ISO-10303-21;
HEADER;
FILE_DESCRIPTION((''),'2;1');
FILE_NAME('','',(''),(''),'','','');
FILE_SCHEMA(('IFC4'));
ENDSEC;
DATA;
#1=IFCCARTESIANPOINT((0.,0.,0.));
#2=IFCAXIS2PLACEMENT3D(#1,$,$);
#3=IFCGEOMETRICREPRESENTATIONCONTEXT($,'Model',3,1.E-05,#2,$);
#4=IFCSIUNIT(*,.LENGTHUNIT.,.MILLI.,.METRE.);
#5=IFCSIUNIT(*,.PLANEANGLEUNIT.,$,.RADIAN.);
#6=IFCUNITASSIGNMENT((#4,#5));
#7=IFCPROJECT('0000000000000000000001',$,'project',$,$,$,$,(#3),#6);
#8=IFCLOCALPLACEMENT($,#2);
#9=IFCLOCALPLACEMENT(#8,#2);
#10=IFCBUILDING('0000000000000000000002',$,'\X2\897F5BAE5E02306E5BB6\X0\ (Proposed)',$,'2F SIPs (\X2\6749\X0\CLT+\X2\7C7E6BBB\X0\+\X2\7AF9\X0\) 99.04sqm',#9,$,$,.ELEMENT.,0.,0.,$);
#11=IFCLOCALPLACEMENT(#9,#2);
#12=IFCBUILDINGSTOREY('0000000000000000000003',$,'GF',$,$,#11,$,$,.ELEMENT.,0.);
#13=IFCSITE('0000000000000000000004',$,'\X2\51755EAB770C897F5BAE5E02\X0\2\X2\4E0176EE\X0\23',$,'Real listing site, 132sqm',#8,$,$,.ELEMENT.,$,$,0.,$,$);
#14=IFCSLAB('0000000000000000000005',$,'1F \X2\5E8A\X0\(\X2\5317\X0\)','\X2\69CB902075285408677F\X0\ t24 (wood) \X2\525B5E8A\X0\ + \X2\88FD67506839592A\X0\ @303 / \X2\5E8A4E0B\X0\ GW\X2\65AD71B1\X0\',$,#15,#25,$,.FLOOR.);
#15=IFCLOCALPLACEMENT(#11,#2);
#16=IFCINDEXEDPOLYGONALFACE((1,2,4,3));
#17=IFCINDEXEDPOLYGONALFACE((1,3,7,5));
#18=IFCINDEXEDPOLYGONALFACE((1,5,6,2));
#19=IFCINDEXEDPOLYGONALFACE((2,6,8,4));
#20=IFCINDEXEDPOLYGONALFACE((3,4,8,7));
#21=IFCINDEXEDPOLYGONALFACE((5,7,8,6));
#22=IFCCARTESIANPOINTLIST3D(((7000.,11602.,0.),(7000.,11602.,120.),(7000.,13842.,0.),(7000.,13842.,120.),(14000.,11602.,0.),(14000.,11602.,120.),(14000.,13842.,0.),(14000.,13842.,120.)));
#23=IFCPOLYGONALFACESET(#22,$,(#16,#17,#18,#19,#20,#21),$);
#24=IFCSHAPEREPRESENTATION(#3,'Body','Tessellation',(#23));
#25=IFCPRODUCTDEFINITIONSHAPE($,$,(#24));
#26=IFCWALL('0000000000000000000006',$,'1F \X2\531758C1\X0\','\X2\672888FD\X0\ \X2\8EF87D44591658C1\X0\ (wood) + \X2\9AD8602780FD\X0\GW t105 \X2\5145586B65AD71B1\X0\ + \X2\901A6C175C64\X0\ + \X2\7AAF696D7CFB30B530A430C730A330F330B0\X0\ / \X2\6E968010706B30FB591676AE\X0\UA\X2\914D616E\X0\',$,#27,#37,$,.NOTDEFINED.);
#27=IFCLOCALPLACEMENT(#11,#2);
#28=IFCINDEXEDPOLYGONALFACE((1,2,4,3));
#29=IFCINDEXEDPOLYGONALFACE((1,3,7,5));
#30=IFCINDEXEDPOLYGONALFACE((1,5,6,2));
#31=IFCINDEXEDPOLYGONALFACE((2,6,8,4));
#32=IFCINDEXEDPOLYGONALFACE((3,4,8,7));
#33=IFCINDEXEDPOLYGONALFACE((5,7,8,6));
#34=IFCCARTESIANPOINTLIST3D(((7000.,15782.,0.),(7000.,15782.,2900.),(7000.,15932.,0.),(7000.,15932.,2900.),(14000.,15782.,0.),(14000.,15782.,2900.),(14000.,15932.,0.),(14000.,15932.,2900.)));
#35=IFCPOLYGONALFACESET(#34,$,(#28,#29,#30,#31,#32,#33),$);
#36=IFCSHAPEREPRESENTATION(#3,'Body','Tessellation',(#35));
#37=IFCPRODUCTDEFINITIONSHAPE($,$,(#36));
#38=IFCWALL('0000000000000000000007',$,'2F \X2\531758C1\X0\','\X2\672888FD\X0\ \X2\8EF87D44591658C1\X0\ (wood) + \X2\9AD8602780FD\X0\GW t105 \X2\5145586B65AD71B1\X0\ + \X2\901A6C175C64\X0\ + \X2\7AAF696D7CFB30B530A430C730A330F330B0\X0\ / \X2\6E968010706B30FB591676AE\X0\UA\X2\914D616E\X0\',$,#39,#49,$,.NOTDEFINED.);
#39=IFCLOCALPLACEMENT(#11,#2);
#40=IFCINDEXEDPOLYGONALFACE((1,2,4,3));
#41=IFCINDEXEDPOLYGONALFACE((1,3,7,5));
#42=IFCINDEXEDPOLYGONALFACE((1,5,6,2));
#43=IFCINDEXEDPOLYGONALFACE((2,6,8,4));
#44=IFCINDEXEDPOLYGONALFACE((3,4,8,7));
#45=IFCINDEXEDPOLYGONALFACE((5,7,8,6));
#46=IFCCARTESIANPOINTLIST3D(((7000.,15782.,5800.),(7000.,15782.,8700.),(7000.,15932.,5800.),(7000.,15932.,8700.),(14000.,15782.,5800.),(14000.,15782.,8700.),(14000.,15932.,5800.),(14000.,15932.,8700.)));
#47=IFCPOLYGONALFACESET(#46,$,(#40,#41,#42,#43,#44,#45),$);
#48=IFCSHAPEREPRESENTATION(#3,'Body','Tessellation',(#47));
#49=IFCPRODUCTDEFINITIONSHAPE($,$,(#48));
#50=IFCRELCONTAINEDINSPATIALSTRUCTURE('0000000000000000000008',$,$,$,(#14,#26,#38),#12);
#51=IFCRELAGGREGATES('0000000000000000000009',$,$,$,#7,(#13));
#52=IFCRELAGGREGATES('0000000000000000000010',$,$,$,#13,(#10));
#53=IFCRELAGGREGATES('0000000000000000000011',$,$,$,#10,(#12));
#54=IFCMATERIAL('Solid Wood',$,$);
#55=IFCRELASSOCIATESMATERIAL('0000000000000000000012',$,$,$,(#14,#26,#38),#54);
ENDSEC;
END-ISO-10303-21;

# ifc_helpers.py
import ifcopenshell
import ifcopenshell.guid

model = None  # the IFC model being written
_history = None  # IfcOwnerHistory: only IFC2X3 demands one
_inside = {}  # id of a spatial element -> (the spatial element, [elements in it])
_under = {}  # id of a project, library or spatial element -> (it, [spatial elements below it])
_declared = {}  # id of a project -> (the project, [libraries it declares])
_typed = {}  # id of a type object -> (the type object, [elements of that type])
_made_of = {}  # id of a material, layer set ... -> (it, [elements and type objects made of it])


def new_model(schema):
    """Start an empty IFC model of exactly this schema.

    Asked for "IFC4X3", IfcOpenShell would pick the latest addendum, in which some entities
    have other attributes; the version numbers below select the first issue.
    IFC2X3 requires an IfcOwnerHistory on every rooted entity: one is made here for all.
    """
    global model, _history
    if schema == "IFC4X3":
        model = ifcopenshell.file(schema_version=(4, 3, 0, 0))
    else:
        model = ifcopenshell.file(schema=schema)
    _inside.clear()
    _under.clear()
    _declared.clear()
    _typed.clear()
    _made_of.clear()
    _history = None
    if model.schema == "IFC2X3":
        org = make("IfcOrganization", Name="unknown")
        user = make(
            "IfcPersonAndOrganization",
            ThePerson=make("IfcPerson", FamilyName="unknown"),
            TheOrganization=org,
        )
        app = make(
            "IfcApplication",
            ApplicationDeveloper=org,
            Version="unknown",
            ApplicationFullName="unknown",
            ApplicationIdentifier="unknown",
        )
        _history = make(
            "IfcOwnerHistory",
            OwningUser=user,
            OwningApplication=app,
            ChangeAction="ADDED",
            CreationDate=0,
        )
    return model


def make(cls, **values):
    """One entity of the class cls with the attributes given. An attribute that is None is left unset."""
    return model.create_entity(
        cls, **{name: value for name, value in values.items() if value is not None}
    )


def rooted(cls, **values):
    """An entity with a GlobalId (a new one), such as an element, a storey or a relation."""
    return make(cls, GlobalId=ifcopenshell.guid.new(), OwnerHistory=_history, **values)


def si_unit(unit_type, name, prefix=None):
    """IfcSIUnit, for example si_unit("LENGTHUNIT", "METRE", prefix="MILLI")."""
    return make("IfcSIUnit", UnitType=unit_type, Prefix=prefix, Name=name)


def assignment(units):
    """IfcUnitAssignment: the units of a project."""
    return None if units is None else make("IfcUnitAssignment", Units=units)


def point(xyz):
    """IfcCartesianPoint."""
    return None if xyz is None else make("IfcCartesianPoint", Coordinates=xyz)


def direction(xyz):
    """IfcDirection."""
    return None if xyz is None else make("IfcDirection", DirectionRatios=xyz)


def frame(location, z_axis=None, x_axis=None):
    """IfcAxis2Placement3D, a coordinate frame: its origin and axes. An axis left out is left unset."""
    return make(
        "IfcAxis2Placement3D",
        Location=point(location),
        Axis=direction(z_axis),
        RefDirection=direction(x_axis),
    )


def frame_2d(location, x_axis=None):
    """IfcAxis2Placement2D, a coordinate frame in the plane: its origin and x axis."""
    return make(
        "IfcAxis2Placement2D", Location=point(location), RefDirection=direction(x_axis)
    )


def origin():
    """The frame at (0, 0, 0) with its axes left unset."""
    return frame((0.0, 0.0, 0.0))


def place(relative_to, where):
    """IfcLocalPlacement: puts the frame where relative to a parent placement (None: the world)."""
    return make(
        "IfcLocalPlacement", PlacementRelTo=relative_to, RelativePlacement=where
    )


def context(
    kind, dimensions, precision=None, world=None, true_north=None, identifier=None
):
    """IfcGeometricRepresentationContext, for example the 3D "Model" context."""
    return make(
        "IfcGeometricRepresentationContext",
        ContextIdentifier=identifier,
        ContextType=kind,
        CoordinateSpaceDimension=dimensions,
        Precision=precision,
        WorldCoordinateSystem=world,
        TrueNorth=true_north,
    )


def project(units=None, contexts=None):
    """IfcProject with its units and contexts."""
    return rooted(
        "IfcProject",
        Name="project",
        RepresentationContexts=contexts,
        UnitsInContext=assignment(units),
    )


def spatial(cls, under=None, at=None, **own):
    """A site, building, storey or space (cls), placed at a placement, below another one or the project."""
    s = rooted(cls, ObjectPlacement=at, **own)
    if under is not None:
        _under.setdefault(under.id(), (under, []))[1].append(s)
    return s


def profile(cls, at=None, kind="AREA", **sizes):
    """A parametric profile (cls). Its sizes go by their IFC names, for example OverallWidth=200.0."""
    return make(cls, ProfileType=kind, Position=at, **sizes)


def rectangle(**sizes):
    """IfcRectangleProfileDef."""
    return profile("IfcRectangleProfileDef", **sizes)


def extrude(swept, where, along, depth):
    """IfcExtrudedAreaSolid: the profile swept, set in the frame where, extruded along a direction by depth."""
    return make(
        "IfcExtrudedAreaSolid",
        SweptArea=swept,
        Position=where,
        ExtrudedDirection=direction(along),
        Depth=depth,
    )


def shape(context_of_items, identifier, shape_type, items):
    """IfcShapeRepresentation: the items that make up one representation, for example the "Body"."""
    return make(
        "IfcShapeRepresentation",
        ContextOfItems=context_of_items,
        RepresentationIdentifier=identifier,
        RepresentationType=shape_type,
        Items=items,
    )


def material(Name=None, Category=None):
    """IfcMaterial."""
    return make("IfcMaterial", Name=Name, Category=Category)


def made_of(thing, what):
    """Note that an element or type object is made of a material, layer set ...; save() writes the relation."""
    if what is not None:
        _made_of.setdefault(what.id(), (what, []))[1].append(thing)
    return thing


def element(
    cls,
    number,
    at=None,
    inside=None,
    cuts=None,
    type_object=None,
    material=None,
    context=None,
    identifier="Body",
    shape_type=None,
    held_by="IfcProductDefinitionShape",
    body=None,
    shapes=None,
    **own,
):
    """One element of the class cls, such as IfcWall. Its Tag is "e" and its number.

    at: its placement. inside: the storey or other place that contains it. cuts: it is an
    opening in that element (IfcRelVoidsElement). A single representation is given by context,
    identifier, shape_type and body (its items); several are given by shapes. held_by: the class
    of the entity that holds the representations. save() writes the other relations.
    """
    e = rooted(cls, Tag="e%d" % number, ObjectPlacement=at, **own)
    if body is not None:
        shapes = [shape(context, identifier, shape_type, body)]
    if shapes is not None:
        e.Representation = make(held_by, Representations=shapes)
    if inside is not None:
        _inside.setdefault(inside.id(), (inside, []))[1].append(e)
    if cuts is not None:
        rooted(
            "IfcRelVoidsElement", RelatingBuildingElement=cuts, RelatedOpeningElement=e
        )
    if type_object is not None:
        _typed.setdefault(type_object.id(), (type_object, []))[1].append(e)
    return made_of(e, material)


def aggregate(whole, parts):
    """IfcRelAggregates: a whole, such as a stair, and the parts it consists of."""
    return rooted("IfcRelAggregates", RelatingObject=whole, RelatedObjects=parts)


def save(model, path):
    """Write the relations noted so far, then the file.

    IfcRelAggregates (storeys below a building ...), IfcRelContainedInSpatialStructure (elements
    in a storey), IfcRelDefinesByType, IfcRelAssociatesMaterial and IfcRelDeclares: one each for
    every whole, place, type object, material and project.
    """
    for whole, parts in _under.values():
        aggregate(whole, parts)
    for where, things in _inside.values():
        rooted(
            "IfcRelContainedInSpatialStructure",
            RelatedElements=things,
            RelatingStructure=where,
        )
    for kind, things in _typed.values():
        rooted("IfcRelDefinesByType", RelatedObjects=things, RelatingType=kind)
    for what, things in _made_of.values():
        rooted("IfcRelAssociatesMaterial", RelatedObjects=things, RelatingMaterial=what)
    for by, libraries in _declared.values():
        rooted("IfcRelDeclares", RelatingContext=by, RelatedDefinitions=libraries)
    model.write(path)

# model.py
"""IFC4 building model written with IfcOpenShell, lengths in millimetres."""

from ifc_helpers import new_model, si_unit, frame, frame_2d, origin, place, context, project, spatial, rectangle, extrude, material, element, save


model = new_model("IFC4")

# Units and contexts
model_context = context("Model", 3, precision=1e-05, world=origin())
ifc_project = project(units=[si_unit("LENGTHUNIT", "METRE", prefix="MILLI"), si_unit("PLANEANGLEUNIT", "RADIAN")], contexts=[model_context])

# Site, building, storey
site_placement = place(None, origin())
site = spatial("IfcSite", under=ifc_project, at=site_placement, Name="兵庫県西宮市2丁目23", ObjectType="Real listing site, 132sqm", CompositionType="ELEMENT", RefElevation=0.0)
building_placement = place(site_placement, origin())
building = spatial("IfcBuilding", under=site, at=building_placement, Name="西宮市の家 (Proposed)", ObjectType="2F SIPs (杉CLT+籾殻+竹) 99.04sqm", CompositionType="ELEMENT", ElevationOfRefHeight=0.0, ElevationOfTerrain=0.0)
storey_placement = place(building_placement, origin())
storey = spatial("IfcBuildingStorey", under=building, at=storey_placement, Name="GF", CompositionType="ELEMENT", Elevation=0.0)

# Slab
ifc_material_1 = material(Name="Solid Wood")
slab_1_placement = place(storey_placement, frame((3500.0, 5801.0, 0.0)))
element("IfcSlab", 1, at=slab_1_placement, inside=storey, material=ifc_material_1, Name="1F 床(北)", Description="構造用合板 t24 (wood) 剛床 + 製材根太 @303 / 床下 GW断熱", PredefinedType="FLOOR", context=model_context, shape_type="SweptSolid", body=[
    extrude(rectangle(XDim=7000.0, YDim=2240.0, at=frame_2d((3500.0, 1120.0))), frame((3500.0, 5801.0, 0.0)), (0.0, 0.0, 1.0), 120.0),
])

# Wall
wall_1_placement = place(storey_placement, frame((3500.0, 7891.0, 0.0)))
element("IfcWall", 2, at=wall_1_placement, inside=storey, material=ifc_material_1, Name="1F 北壁", Description="木製 軸組外壁 (wood) + 高性能GW t105 充填断熱 + 通気層 + 窯業系サイディング / 準耐火・外皮UA配慮", PredefinedType="NOTDEFINED", context=model_context, shape_type="SweptSolid", body=[
    extrude(rectangle(XDim=7000.0, YDim=150.0, at=frame_2d((3500.0, 75.0))), frame((3500.0, 7891.0, 0.0)), (0.0, 0.0, 1.0), 2900.0),
])

# Wall
wall_2_placement = place(storey_placement, frame((3500.0, 7891.0, 2900.0)))
element("IfcWall", 3, at=wall_2_placement, inside=storey, material=ifc_material_1, Name="2F 北壁", Description="木製 軸組外壁 (wood) + 高性能GW t105 充填断熱 + 通気層 + 窯業系サイディング / 準耐火・外皮UA配慮", PredefinedType="NOTDEFINED", context=model_context, shape_type="SweptSolid", body=[
    extrude(rectangle(XDim=7000.0, YDim=150.0, at=frame_2d((3500.0, 75.0))), frame((3500.0, 7891.0, 2900.0)), (0.0, 0.0, 1.0), 2900.0),
])

save(model, "model.ifc")
